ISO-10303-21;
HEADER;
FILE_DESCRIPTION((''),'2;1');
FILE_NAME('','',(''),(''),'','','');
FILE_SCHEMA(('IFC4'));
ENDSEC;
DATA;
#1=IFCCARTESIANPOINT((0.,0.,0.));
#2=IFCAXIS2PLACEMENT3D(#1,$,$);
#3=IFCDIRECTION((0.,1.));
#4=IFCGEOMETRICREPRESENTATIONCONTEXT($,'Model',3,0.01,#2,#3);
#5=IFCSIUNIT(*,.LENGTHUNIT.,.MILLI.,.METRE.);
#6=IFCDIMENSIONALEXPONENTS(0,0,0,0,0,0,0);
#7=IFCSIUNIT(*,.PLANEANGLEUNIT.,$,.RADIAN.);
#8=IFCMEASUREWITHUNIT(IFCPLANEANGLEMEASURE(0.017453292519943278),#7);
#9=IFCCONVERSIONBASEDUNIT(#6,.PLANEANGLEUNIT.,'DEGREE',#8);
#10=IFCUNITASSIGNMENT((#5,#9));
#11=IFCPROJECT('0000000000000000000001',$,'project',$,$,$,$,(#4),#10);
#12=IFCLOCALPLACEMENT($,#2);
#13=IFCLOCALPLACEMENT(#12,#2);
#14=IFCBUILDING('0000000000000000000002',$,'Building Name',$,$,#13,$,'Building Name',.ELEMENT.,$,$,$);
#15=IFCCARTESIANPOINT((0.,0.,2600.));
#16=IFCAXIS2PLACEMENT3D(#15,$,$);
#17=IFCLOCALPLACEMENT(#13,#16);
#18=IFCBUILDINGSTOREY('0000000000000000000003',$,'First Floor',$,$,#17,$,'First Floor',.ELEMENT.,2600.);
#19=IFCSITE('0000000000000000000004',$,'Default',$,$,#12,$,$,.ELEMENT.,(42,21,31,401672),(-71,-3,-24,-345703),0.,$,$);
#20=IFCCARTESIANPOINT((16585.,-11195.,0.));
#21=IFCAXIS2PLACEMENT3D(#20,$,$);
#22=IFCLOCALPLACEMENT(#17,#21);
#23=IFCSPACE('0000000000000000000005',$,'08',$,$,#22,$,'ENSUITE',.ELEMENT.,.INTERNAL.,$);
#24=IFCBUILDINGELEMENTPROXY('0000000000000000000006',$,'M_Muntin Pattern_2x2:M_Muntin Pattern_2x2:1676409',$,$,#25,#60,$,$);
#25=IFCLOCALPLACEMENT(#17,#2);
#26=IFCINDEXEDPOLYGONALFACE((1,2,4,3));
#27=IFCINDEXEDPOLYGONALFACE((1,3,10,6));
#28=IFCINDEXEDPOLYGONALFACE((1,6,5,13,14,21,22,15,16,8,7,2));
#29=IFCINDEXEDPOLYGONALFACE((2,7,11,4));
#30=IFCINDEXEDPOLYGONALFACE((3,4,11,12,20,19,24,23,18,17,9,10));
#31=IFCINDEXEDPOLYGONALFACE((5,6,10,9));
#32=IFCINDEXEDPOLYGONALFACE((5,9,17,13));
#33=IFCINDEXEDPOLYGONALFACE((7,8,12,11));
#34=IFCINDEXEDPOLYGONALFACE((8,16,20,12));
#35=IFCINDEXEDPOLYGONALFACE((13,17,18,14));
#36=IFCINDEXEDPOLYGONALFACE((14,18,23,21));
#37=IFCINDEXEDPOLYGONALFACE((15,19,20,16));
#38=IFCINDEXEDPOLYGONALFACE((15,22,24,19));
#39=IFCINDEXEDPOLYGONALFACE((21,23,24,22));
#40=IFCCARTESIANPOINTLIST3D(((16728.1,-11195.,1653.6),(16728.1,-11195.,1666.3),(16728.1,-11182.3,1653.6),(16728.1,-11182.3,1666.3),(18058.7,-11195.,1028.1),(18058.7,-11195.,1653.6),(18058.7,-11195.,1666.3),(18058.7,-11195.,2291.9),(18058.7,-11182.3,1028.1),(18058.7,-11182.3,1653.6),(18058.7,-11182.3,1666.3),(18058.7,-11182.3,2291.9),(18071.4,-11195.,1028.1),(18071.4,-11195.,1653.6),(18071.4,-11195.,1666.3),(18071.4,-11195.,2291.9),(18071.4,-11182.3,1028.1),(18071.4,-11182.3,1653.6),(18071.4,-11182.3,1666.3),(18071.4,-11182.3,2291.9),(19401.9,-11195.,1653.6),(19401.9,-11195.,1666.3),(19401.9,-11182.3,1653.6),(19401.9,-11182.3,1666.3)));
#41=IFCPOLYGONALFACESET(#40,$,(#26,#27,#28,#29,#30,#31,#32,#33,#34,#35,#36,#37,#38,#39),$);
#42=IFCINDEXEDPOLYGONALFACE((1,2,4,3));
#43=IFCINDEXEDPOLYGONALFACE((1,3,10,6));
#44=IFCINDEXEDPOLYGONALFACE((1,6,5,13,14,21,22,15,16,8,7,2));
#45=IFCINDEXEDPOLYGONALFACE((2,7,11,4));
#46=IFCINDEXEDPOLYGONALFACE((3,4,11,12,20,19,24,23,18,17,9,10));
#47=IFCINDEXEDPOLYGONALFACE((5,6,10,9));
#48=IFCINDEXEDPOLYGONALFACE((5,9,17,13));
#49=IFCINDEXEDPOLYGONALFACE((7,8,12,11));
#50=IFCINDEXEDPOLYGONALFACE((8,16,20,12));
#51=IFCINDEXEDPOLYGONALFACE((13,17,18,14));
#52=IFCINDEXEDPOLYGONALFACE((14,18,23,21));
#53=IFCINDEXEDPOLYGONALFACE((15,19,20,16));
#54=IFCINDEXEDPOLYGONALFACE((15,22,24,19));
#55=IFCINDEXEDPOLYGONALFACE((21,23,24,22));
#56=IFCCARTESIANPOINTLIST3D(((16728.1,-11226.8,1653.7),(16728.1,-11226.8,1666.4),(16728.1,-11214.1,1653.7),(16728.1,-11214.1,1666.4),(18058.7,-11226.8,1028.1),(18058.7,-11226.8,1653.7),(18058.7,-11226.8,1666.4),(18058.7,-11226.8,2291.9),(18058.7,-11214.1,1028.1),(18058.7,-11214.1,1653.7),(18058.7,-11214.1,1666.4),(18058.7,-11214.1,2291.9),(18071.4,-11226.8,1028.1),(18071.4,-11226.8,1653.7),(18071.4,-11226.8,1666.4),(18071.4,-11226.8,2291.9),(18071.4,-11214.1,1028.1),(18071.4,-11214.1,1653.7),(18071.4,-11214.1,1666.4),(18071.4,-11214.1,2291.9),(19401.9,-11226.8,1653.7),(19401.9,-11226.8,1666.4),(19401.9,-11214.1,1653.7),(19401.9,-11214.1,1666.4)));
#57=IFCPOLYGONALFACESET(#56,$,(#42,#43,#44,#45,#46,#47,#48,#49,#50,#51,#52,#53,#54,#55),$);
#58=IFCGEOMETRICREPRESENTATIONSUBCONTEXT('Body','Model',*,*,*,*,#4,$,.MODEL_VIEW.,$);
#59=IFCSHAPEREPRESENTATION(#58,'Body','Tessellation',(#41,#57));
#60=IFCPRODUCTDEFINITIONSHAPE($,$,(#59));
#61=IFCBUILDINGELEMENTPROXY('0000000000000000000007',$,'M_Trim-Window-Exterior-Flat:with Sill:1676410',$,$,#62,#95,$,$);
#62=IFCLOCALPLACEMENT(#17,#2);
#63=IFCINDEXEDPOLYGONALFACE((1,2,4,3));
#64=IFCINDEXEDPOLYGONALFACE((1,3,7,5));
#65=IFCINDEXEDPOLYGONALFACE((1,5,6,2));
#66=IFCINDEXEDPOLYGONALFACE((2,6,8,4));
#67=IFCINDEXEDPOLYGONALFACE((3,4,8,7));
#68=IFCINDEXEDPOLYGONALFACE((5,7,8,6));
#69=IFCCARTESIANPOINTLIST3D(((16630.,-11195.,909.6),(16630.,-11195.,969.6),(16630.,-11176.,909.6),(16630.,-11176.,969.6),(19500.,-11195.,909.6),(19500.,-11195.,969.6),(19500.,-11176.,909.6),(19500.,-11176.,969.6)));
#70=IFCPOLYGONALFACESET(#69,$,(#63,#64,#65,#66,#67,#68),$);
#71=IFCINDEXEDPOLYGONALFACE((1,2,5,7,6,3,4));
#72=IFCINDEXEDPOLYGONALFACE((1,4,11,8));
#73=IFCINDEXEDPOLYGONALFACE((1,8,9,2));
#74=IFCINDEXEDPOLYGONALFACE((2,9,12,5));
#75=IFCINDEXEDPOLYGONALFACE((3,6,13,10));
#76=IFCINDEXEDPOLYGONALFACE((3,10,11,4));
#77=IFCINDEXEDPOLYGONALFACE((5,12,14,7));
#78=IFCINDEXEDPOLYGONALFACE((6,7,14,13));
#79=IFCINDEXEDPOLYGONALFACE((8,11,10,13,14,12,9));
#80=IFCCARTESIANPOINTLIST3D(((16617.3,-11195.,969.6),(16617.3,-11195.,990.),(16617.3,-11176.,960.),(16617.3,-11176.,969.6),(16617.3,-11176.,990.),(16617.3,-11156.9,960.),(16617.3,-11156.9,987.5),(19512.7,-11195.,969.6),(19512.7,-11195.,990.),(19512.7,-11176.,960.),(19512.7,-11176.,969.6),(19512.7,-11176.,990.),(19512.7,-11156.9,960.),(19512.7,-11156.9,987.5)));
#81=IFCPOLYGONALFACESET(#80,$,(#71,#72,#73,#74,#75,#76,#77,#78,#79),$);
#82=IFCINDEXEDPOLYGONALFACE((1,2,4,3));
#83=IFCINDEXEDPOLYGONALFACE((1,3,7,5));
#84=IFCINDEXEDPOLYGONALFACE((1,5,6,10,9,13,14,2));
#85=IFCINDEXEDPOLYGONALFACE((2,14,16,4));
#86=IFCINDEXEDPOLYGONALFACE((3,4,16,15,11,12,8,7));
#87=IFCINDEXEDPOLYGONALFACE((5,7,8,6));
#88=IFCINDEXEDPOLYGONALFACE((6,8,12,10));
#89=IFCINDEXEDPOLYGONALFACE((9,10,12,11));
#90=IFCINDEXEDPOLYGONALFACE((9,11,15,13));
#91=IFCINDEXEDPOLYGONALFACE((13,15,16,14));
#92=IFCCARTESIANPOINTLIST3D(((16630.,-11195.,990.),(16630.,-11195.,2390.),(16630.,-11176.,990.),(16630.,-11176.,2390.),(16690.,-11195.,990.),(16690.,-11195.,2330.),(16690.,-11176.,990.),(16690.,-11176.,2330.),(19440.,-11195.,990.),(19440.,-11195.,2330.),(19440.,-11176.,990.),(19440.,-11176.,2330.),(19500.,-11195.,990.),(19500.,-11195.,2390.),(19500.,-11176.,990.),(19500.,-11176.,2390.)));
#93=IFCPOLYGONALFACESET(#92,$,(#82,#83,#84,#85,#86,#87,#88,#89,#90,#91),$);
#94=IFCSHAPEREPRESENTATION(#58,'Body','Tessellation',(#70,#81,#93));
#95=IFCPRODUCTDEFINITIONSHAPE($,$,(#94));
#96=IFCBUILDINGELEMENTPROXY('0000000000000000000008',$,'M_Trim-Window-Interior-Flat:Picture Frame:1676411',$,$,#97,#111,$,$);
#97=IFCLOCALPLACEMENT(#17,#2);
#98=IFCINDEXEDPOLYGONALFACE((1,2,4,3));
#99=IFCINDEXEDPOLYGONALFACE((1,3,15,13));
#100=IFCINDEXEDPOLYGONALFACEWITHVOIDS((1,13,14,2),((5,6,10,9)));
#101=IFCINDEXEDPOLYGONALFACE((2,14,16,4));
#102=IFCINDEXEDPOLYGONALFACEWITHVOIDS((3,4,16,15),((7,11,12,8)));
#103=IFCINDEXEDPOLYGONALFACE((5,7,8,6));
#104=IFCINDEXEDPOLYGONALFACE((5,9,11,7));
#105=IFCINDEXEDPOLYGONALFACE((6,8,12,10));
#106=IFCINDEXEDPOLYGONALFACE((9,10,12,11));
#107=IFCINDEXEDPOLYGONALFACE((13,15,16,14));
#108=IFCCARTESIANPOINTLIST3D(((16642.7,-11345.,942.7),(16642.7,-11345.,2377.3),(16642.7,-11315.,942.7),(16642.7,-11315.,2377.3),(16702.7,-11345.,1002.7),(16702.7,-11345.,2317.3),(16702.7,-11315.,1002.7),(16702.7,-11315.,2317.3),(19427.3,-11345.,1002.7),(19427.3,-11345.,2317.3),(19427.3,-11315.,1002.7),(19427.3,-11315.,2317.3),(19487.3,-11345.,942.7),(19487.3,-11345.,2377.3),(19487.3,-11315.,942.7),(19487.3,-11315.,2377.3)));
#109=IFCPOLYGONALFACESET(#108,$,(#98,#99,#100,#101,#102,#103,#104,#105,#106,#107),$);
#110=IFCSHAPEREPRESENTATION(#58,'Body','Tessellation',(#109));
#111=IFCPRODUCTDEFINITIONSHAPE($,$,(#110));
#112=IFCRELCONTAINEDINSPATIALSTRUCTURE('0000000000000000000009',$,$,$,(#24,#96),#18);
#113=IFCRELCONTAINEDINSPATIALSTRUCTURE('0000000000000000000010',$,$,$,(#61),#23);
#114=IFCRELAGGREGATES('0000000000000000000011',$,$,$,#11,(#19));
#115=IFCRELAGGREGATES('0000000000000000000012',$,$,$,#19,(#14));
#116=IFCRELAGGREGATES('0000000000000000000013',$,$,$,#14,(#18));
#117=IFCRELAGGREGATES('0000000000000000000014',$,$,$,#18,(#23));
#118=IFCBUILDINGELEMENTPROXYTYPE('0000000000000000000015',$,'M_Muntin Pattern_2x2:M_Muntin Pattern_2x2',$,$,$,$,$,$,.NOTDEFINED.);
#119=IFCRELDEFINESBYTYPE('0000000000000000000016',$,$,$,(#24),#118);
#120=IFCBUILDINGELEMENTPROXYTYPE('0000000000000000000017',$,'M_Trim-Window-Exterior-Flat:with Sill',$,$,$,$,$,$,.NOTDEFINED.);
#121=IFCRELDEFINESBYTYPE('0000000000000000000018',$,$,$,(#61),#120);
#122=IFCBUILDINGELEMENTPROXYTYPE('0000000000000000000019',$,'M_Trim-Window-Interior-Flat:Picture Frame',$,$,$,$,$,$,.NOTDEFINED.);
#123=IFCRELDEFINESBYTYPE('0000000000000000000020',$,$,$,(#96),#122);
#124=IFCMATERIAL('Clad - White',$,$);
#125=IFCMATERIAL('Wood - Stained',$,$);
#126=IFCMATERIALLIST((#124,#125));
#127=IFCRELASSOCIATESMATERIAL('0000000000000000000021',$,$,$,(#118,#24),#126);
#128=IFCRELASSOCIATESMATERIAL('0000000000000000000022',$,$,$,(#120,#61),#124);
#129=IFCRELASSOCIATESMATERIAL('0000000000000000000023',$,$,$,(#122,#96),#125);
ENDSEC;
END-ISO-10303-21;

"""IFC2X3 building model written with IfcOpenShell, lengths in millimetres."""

from ifc_helpers import new_model, entity, si_unit, converted_unit, direction, frame, frame_2d, origin, place, context, subcontext, project, spatial, polyline, rectangle, outline, extrude, source, transform, mapped, material, material_list, type_object, type_shapes, element, save


model = new_model("IFC2X3")

# Units and contexts
model_context = context("Model", 3, precision=0.01, world=origin(), true_north=direction((0.0, 1.0)))
body_context = subcontext(model_context, "Body", "Model", "MODEL_VIEW")
ifc_project = project(units=[si_unit("LENGTHUNIT", "METRE", prefix="MILLI"), converted_unit("PLANEANGLEUNIT", "DEGREE", entity("IfcPlaneAngleMeasure", 0.017453292519943278), si_unit("PLANEANGLEUNIT", "RADIAN"), dimensions=[0, 0, 0, 0, 0, 0, 0])], contexts=[model_context])

# Site, building, storey
site_placement = place(None, origin())
site = spatial("IfcSite", under=ifc_project, at=site_placement, Name="Default", CompositionType="ELEMENT", RefLatitude=(42, 21, 31, 401672), RefLongitude=(-71, -3, -24, -345703), RefElevation=0.0)
building_placement = place(site_placement, origin())
building = spatial("IfcBuilding", under=site, at=building_placement, Name="Building Name", LongName="Building Name", CompositionType="ELEMENT")
storey_placement = place(building_placement, frame((0.0, 0.0, 2600.0)))
storey = spatial("IfcBuildingStorey", under=building, at=storey_placement, Name="First Floor", LongName="First Floor", CompositionType="ELEMENT", Elevation=2600.0)

# Shared definitions
space_1_placement = place(storey_placement, frame((16585.0, -11195.0, 0.0)))
space_1 = spatial("IfcSpace", under=storey, at=space_1_placement, Name="08", LongName="ENSUITE", CompositionType="ELEMENT", InteriorOrExteriorSpace="INTERNAL")

# Shared definitions
ifc_material_1 = material(Name="Clad - White")
ifc_material_2 = material(Name="Wood - Stained")
ifc_material_list_1 = material_list([ifc_material_1, ifc_material_2])

# Building element proxies
building_element_proxy_type_1 = type_object("IfcBuildingElementProxyType", Name="M_Muntin Pattern_2x2:M_Muntin Pattern_2x2", PredefinedType="NOTDEFINED", material=ifc_material_list_1)
shared_shape_1 = source(origin(), body_context, "Body", "SweptSolid", [
    extrude(outline(polyline([(6.4, -6.4), (631.9, -6.4), (631.9, 6.3), (6.4, 6.3), (6.4, 1336.9), (-6.3, 1336.9), (-6.3, 6.3), (-631.9, 6.3), (-631.9, -6.4), (-6.3, -6.4), (-6.3, -1336.9), (6.4, -1336.9), (6.4, -6.4)])), frame((0.0, -22.2, 631.9), z_axis=(0.0, 1.0, 0.0), x_axis=(0.0, 0.0, 1.0)), (0.0, 0.0, 1.0), 12.7),
    extrude(outline(polyline([(6.4, -6.4), (631.9, -6.4), (631.9, 6.3), (6.4, 6.3), (6.4, 1336.9), (-6.3, 1336.9), (-6.3, 6.3), (-631.9, 6.3), (-631.9, -6.4), (-6.3, -6.4), (-6.3, -1336.9), (6.4, -1336.9), (6.4, -6.4)])), frame((0.0, 9.5, 631.9), z_axis=(0.0, 1.0, 0.0), x_axis=(0.0, 0.0, 1.0)), (0.0, 0.0, 1.0), 12.7),
])
type_shapes(building_element_proxy_type_1, [shared_shape_1])
proxy_1_placement = place(storey_placement, frame((18065.0, -11204.5, 1028.1), z_axis=(0.0, 0.0, 1.0), x_axis=(-1.0, 0.0, 0.0)))
element("IfcBuildingElementProxy", 1, at=proxy_1_placement, inside=storey, type_object=building_element_proxy_type_1, material=ifc_material_list_1, Name="M_Muntin Pattern_2x2:M_Muntin Pattern_2x2:1676409", context=body_context, shape_type="MappedRepresentation", body=[
    mapped(shared_shape_1, transform((0.0, 0.0, 0.0), scale=1.0)),
])
building_element_proxy_type_2 = type_object("IfcBuildingElementProxyType", Name="M_Trim-Window-Exterior-Flat:with Sill", PredefinedType="NOTDEFINED", material=ifc_material_1)
shared_shape_2 = source(origin(), body_context, "Body", "SweptSolid", [
    extrude(rectangle(XDim=2870.0, YDim=60.0, at=frame_2d((0.0, 0.0), x_axis=(1.0, 0.0))), frame((0.0, -1390.4, 0.0), z_axis=(0.0, 0.0, 1.0), x_axis=(-1.0, 0.0, 0.0)), (0.0, 0.0, 1.0), 19.0),
    extrude(outline(polyline([(-19.0, -15.2), (0.0, -15.2), (0.0, -5.7), (19.0, -5.7), (19.0, 14.8), (0.0, 14.8), (-19.0, 12.3), (-19.0, -15.2)])), frame((-1447.7, -1354.8, 19.0), z_axis=(1.0, 0.0, 0.0), x_axis=(0.0, 0.0, -1.0)), (0.0, 0.0, 1.0), 2895.4),
    extrude(outline(polyline([(-715.0, -1435.0), (685.0, -1435.0), (685.0, -1375.0), (-655.0, -1375.0), (-655.0, 1375.0), (685.0, 1375.0), (685.0, 1435.0), (-715.0, 1435.0), (-715.0, -1435.0)])), frame((0.0, -655.0, 0.0), z_axis=(0.0, 0.0, 1.0), x_axis=(0.0, -1.0, 0.0)), (0.0, 0.0, 1.0), 19.0),
])
type_shapes(building_element_proxy_type_2, [shared_shape_2])
proxy_2_placement = place(space_1_placement, frame((1480.0, 0.0, 2330.0), z_axis=(0.0, 1.0, 0.0), x_axis=(-1.0, 0.0, 0.0)))
element("IfcBuildingElementProxy", 2, at=proxy_2_placement, inside=space_1, type_object=building_element_proxy_type_2, material=ifc_material_1, Name="M_Trim-Window-Exterior-Flat:with Sill:1676410", context=body_context, shape_type="MappedRepresentation", body=[
    mapped(shared_shape_2, transform((0.0, 0.0, 0.0), scale=1.0)),
])
building_element_proxy_type_3 = type_object("IfcBuildingElementProxyType", Name="M_Trim-Window-Interior-Flat:Picture Frame", PredefinedType="NOTDEFINED", material=ifc_material_2)
shared_shape_3 = source(origin(), body_context, "Body", "SweptSolid", [
    extrude(outline(polyline([(-1422.3, -717.3), (1422.3, -717.3), (1422.3, 717.3), (-1422.3, 717.3), (-1422.3, -717.3)]), holes=[polyline([(-1362.3, -657.3), (-1362.3, 657.3), (1362.3, 657.3), (1362.3, -657.3), (-1362.3, -657.3)])]), frame((0.0, -670.0, 0.0), z_axis=(0.0, 0.0, 1.0), x_axis=(-1.0, 0.0, 0.0)), (0.0, 0.0, 1.0), 30.0),
])
type_shapes(building_element_proxy_type_3, [shared_shape_3])
proxy_3_placement = place(storey_placement, frame((18065.0, -11315.0, 2330.0), z_axis=(0.0, -1.0, 0.0), x_axis=(1.0, 0.0, 0.0)))
element("IfcBuildingElementProxy", 3, at=proxy_3_placement, inside=storey, type_object=building_element_proxy_type_3, material=ifc_material_2, Name="M_Trim-Window-Interior-Flat:Picture Frame:1676411", context=body_context, shape_type="MappedRepresentation", body=[
    mapped(shared_shape_3, transform((0.0, 0.0, 0.0), scale=1.0)),
])

save(model, "model.ifc")
